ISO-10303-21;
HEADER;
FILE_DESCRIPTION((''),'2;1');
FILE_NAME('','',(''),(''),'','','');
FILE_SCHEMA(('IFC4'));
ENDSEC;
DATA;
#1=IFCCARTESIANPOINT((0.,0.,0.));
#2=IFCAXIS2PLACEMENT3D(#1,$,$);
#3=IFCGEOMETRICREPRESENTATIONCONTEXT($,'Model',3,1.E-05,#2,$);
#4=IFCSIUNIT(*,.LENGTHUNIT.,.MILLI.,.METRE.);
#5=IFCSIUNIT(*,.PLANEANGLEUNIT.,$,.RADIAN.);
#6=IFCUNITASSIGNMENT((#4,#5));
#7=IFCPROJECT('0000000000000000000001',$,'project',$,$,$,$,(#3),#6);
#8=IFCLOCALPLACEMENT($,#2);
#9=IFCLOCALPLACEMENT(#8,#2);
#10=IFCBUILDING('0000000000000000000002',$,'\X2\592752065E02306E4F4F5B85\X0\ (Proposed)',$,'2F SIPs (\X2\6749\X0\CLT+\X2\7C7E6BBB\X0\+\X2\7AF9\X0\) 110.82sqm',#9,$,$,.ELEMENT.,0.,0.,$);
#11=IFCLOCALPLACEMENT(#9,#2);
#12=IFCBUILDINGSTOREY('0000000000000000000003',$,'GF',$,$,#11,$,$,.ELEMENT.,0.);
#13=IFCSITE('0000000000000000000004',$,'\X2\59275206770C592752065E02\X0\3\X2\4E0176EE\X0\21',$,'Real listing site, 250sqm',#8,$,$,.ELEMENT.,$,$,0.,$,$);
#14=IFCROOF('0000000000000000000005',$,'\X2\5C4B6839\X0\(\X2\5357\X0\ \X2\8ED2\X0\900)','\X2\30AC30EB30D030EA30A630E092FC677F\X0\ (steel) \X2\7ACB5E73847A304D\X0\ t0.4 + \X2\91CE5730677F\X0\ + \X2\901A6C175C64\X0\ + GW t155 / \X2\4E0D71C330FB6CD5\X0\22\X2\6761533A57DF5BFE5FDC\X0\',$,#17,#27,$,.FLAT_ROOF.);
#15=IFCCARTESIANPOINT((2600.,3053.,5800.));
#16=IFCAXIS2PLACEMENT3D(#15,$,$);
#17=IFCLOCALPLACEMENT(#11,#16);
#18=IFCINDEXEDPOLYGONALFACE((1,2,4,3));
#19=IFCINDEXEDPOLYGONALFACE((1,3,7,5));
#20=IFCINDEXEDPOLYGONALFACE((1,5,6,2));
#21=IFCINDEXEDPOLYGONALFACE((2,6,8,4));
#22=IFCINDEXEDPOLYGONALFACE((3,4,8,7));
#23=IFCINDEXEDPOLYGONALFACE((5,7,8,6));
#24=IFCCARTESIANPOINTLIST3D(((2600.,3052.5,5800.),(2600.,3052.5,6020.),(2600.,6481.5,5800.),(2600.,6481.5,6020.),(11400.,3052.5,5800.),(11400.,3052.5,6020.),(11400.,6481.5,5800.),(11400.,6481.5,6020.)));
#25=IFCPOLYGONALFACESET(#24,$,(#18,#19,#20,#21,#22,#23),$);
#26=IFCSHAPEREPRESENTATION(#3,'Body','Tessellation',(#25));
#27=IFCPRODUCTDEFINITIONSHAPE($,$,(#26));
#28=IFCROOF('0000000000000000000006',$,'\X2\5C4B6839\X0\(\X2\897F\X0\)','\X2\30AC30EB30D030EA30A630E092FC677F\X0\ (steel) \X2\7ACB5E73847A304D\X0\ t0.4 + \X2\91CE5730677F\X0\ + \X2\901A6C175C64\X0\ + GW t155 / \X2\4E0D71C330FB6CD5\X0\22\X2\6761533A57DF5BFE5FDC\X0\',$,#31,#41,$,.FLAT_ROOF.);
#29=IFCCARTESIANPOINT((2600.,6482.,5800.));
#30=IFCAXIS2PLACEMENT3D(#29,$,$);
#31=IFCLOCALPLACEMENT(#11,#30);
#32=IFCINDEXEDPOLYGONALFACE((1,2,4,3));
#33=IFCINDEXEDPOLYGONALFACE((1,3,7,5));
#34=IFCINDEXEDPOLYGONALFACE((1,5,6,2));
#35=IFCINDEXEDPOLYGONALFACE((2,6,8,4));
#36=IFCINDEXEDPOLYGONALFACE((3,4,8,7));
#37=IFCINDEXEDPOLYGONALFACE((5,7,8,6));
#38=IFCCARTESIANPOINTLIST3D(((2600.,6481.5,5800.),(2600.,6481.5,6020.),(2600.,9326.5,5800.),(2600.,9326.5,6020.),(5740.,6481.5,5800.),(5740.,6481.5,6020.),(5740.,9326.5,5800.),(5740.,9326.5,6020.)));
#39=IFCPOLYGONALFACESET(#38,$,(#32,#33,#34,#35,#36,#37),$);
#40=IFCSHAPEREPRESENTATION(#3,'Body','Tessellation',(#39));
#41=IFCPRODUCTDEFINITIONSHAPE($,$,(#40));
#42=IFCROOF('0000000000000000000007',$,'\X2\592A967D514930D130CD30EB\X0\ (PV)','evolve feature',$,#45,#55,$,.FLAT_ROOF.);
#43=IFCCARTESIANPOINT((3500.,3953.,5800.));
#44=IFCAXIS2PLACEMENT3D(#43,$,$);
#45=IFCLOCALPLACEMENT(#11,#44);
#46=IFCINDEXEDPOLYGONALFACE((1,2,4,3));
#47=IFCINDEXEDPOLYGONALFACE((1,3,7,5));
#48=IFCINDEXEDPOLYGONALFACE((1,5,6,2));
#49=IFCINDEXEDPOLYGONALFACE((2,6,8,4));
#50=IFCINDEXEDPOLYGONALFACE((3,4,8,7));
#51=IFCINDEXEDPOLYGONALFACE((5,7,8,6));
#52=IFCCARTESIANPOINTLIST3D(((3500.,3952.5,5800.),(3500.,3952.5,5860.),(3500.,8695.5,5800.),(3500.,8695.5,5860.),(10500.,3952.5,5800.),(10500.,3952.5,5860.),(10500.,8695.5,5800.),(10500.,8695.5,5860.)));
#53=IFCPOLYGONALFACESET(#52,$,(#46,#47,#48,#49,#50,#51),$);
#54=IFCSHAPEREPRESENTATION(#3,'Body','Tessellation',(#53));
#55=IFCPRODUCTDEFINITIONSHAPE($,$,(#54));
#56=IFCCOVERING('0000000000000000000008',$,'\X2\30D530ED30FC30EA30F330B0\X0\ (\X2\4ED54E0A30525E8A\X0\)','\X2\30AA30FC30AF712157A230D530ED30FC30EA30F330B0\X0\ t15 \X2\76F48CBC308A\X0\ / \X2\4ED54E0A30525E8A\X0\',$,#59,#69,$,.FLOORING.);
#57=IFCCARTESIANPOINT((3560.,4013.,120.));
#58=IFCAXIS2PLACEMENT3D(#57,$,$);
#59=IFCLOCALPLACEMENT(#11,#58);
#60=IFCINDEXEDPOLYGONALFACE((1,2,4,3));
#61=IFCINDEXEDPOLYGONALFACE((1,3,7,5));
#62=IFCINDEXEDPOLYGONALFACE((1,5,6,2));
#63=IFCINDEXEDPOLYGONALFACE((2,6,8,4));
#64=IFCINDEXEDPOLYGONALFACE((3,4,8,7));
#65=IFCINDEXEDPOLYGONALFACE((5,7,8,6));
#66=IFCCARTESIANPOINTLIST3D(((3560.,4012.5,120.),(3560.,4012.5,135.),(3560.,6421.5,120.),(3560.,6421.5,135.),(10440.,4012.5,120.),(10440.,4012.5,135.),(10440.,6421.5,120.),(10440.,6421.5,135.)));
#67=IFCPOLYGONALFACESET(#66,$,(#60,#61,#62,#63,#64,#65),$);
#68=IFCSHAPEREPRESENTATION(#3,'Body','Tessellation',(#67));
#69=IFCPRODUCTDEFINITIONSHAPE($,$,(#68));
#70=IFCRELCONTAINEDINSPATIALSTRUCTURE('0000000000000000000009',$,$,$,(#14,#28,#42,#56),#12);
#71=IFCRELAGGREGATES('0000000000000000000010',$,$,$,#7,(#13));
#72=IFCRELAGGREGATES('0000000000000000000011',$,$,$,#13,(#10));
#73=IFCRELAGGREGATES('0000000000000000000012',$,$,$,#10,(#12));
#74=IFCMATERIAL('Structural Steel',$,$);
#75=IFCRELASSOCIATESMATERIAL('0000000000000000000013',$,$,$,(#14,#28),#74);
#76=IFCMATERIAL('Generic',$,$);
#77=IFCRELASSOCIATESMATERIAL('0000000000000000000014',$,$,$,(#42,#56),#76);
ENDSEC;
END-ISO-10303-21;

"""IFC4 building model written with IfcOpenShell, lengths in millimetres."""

from ifc_helpers import new_model, si_unit, frame, frame_2d, origin, place, context, project, spatial, rectangle, extrude, material, element, save


model = new_model("IFC4")

# Units and contexts
model_context = context("Model", 3, precision=1e-05, world=origin())
ifc_project = project(units=[si_unit("LENGTHUNIT", "METRE", prefix="MILLI"), si_unit("PLANEANGLEUNIT", "RADIAN")], contexts=[model_context])

# Site, building, storey
site_placement = place(None, origin())
site = spatial("IfcSite", under=ifc_project, at=site_placement, Name="大分県大分市3丁目21", ObjectType="Real listing site, 250sqm", CompositionType="ELEMENT", RefElevation=0.0)
building_placement = place(site_placement, origin())
building = spatial("IfcBuilding", under=site, at=building_placement, Name="大分市の住宅 (Proposed)", ObjectType="2F SIPs (杉CLT+籾殻+竹) 110.82sqm", CompositionType="ELEMENT", ElevationOfRefHeight=0.0, ElevationOfTerrain=0.0)
storey_placement = place(building_placement, origin())
storey = spatial("IfcBuildingStorey", under=building, at=storey_placement, Name="GF", CompositionType="ELEMENT", Elevation=0.0)

# Shared definitions
ifc_material_1 = material(Name="Generic")

# Roofs
ifc_material_2 = material(Name="Structural Steel")
roof_1_placement = place(storey_placement, frame((2600.0, 3053.0, 5800.0)))
element("IfcRoof", 1, at=roof_1_placement, inside=storey, material=ifc_material_2, Name="屋根(南 軒900)", Description="ガルバリウム鋼板 (steel) 立平葺き t0.4 + 野地板 + 通気層 + GW t155 / 不燃・法22条区域対応", PredefinedType="FLAT_ROOF", context=model_context, shape_type="SweptSolid", body=[
    extrude(rectangle(XDim=8800.0, YDim=3429.0, at=frame_2d((4400.0, 1714.0))), frame((2600.0, 3053.0, 5800.0)), (0.0, 0.0, 1.0), 220.0),
])
roof_2_placement = place(storey_placement, frame((2600.0, 6482.0, 5800.0)))
element("IfcRoof", 2, at=roof_2_placement, inside=storey, material=ifc_material_2, Name="屋根(西)", Description="ガルバリウム鋼板 (steel) 立平葺き t0.4 + 野地板 + 通気層 + GW t155 / 不燃・法22条区域対応", PredefinedType="FLAT_ROOF", context=model_context, shape_type="SweptSolid", body=[
    extrude(rectangle(XDim=3140.0, YDim=2845.0, at=frame_2d((1570.0, 1422.0))), frame((2600.0, 6482.0, 5800.0)), (0.0, 0.0, 1.0), 220.0),
])
roof_3_placement = place(storey_placement, frame((3500.0, 3953.0, 5800.0)))
element("IfcRoof", 3, at=roof_3_placement, inside=storey, material=ifc_material_1, Name="太陽光パネル (PV)", Description="evolve feature", PredefinedType="FLAT_ROOF", context=model_context, shape_type="SweptSolid", body=[
    extrude(rectangle(XDim=7000.0, YDim=4743.0, at=frame_2d((3500.0, 2371.0))), frame((3500.0, 3953.0, 5800.0)), (0.0, 0.0, 1.0), 60.0),
])

# Covering
covering_placement = place(storey_placement, frame((3560.0, 4013.0, 120.0)))
element("IfcCovering", 4, at=covering_placement, inside=storey, material=ifc_material_1, Name="フローリング (仕上げ床)", Description="オーク無垢フローリング t15 直貼り / 仕上げ床", PredefinedType="FLOORING", context=model_context, shape_type="SweptSolid", body=[
    extrude(rectangle(XDim=6880.0, YDim=2409.0, at=frame_2d((3440.0, 1204.0))), frame((3560.0, 4013.0, 120.0)), (0.0, 0.0, 1.0), 15.0),
])

save(model, "model.ifc")
